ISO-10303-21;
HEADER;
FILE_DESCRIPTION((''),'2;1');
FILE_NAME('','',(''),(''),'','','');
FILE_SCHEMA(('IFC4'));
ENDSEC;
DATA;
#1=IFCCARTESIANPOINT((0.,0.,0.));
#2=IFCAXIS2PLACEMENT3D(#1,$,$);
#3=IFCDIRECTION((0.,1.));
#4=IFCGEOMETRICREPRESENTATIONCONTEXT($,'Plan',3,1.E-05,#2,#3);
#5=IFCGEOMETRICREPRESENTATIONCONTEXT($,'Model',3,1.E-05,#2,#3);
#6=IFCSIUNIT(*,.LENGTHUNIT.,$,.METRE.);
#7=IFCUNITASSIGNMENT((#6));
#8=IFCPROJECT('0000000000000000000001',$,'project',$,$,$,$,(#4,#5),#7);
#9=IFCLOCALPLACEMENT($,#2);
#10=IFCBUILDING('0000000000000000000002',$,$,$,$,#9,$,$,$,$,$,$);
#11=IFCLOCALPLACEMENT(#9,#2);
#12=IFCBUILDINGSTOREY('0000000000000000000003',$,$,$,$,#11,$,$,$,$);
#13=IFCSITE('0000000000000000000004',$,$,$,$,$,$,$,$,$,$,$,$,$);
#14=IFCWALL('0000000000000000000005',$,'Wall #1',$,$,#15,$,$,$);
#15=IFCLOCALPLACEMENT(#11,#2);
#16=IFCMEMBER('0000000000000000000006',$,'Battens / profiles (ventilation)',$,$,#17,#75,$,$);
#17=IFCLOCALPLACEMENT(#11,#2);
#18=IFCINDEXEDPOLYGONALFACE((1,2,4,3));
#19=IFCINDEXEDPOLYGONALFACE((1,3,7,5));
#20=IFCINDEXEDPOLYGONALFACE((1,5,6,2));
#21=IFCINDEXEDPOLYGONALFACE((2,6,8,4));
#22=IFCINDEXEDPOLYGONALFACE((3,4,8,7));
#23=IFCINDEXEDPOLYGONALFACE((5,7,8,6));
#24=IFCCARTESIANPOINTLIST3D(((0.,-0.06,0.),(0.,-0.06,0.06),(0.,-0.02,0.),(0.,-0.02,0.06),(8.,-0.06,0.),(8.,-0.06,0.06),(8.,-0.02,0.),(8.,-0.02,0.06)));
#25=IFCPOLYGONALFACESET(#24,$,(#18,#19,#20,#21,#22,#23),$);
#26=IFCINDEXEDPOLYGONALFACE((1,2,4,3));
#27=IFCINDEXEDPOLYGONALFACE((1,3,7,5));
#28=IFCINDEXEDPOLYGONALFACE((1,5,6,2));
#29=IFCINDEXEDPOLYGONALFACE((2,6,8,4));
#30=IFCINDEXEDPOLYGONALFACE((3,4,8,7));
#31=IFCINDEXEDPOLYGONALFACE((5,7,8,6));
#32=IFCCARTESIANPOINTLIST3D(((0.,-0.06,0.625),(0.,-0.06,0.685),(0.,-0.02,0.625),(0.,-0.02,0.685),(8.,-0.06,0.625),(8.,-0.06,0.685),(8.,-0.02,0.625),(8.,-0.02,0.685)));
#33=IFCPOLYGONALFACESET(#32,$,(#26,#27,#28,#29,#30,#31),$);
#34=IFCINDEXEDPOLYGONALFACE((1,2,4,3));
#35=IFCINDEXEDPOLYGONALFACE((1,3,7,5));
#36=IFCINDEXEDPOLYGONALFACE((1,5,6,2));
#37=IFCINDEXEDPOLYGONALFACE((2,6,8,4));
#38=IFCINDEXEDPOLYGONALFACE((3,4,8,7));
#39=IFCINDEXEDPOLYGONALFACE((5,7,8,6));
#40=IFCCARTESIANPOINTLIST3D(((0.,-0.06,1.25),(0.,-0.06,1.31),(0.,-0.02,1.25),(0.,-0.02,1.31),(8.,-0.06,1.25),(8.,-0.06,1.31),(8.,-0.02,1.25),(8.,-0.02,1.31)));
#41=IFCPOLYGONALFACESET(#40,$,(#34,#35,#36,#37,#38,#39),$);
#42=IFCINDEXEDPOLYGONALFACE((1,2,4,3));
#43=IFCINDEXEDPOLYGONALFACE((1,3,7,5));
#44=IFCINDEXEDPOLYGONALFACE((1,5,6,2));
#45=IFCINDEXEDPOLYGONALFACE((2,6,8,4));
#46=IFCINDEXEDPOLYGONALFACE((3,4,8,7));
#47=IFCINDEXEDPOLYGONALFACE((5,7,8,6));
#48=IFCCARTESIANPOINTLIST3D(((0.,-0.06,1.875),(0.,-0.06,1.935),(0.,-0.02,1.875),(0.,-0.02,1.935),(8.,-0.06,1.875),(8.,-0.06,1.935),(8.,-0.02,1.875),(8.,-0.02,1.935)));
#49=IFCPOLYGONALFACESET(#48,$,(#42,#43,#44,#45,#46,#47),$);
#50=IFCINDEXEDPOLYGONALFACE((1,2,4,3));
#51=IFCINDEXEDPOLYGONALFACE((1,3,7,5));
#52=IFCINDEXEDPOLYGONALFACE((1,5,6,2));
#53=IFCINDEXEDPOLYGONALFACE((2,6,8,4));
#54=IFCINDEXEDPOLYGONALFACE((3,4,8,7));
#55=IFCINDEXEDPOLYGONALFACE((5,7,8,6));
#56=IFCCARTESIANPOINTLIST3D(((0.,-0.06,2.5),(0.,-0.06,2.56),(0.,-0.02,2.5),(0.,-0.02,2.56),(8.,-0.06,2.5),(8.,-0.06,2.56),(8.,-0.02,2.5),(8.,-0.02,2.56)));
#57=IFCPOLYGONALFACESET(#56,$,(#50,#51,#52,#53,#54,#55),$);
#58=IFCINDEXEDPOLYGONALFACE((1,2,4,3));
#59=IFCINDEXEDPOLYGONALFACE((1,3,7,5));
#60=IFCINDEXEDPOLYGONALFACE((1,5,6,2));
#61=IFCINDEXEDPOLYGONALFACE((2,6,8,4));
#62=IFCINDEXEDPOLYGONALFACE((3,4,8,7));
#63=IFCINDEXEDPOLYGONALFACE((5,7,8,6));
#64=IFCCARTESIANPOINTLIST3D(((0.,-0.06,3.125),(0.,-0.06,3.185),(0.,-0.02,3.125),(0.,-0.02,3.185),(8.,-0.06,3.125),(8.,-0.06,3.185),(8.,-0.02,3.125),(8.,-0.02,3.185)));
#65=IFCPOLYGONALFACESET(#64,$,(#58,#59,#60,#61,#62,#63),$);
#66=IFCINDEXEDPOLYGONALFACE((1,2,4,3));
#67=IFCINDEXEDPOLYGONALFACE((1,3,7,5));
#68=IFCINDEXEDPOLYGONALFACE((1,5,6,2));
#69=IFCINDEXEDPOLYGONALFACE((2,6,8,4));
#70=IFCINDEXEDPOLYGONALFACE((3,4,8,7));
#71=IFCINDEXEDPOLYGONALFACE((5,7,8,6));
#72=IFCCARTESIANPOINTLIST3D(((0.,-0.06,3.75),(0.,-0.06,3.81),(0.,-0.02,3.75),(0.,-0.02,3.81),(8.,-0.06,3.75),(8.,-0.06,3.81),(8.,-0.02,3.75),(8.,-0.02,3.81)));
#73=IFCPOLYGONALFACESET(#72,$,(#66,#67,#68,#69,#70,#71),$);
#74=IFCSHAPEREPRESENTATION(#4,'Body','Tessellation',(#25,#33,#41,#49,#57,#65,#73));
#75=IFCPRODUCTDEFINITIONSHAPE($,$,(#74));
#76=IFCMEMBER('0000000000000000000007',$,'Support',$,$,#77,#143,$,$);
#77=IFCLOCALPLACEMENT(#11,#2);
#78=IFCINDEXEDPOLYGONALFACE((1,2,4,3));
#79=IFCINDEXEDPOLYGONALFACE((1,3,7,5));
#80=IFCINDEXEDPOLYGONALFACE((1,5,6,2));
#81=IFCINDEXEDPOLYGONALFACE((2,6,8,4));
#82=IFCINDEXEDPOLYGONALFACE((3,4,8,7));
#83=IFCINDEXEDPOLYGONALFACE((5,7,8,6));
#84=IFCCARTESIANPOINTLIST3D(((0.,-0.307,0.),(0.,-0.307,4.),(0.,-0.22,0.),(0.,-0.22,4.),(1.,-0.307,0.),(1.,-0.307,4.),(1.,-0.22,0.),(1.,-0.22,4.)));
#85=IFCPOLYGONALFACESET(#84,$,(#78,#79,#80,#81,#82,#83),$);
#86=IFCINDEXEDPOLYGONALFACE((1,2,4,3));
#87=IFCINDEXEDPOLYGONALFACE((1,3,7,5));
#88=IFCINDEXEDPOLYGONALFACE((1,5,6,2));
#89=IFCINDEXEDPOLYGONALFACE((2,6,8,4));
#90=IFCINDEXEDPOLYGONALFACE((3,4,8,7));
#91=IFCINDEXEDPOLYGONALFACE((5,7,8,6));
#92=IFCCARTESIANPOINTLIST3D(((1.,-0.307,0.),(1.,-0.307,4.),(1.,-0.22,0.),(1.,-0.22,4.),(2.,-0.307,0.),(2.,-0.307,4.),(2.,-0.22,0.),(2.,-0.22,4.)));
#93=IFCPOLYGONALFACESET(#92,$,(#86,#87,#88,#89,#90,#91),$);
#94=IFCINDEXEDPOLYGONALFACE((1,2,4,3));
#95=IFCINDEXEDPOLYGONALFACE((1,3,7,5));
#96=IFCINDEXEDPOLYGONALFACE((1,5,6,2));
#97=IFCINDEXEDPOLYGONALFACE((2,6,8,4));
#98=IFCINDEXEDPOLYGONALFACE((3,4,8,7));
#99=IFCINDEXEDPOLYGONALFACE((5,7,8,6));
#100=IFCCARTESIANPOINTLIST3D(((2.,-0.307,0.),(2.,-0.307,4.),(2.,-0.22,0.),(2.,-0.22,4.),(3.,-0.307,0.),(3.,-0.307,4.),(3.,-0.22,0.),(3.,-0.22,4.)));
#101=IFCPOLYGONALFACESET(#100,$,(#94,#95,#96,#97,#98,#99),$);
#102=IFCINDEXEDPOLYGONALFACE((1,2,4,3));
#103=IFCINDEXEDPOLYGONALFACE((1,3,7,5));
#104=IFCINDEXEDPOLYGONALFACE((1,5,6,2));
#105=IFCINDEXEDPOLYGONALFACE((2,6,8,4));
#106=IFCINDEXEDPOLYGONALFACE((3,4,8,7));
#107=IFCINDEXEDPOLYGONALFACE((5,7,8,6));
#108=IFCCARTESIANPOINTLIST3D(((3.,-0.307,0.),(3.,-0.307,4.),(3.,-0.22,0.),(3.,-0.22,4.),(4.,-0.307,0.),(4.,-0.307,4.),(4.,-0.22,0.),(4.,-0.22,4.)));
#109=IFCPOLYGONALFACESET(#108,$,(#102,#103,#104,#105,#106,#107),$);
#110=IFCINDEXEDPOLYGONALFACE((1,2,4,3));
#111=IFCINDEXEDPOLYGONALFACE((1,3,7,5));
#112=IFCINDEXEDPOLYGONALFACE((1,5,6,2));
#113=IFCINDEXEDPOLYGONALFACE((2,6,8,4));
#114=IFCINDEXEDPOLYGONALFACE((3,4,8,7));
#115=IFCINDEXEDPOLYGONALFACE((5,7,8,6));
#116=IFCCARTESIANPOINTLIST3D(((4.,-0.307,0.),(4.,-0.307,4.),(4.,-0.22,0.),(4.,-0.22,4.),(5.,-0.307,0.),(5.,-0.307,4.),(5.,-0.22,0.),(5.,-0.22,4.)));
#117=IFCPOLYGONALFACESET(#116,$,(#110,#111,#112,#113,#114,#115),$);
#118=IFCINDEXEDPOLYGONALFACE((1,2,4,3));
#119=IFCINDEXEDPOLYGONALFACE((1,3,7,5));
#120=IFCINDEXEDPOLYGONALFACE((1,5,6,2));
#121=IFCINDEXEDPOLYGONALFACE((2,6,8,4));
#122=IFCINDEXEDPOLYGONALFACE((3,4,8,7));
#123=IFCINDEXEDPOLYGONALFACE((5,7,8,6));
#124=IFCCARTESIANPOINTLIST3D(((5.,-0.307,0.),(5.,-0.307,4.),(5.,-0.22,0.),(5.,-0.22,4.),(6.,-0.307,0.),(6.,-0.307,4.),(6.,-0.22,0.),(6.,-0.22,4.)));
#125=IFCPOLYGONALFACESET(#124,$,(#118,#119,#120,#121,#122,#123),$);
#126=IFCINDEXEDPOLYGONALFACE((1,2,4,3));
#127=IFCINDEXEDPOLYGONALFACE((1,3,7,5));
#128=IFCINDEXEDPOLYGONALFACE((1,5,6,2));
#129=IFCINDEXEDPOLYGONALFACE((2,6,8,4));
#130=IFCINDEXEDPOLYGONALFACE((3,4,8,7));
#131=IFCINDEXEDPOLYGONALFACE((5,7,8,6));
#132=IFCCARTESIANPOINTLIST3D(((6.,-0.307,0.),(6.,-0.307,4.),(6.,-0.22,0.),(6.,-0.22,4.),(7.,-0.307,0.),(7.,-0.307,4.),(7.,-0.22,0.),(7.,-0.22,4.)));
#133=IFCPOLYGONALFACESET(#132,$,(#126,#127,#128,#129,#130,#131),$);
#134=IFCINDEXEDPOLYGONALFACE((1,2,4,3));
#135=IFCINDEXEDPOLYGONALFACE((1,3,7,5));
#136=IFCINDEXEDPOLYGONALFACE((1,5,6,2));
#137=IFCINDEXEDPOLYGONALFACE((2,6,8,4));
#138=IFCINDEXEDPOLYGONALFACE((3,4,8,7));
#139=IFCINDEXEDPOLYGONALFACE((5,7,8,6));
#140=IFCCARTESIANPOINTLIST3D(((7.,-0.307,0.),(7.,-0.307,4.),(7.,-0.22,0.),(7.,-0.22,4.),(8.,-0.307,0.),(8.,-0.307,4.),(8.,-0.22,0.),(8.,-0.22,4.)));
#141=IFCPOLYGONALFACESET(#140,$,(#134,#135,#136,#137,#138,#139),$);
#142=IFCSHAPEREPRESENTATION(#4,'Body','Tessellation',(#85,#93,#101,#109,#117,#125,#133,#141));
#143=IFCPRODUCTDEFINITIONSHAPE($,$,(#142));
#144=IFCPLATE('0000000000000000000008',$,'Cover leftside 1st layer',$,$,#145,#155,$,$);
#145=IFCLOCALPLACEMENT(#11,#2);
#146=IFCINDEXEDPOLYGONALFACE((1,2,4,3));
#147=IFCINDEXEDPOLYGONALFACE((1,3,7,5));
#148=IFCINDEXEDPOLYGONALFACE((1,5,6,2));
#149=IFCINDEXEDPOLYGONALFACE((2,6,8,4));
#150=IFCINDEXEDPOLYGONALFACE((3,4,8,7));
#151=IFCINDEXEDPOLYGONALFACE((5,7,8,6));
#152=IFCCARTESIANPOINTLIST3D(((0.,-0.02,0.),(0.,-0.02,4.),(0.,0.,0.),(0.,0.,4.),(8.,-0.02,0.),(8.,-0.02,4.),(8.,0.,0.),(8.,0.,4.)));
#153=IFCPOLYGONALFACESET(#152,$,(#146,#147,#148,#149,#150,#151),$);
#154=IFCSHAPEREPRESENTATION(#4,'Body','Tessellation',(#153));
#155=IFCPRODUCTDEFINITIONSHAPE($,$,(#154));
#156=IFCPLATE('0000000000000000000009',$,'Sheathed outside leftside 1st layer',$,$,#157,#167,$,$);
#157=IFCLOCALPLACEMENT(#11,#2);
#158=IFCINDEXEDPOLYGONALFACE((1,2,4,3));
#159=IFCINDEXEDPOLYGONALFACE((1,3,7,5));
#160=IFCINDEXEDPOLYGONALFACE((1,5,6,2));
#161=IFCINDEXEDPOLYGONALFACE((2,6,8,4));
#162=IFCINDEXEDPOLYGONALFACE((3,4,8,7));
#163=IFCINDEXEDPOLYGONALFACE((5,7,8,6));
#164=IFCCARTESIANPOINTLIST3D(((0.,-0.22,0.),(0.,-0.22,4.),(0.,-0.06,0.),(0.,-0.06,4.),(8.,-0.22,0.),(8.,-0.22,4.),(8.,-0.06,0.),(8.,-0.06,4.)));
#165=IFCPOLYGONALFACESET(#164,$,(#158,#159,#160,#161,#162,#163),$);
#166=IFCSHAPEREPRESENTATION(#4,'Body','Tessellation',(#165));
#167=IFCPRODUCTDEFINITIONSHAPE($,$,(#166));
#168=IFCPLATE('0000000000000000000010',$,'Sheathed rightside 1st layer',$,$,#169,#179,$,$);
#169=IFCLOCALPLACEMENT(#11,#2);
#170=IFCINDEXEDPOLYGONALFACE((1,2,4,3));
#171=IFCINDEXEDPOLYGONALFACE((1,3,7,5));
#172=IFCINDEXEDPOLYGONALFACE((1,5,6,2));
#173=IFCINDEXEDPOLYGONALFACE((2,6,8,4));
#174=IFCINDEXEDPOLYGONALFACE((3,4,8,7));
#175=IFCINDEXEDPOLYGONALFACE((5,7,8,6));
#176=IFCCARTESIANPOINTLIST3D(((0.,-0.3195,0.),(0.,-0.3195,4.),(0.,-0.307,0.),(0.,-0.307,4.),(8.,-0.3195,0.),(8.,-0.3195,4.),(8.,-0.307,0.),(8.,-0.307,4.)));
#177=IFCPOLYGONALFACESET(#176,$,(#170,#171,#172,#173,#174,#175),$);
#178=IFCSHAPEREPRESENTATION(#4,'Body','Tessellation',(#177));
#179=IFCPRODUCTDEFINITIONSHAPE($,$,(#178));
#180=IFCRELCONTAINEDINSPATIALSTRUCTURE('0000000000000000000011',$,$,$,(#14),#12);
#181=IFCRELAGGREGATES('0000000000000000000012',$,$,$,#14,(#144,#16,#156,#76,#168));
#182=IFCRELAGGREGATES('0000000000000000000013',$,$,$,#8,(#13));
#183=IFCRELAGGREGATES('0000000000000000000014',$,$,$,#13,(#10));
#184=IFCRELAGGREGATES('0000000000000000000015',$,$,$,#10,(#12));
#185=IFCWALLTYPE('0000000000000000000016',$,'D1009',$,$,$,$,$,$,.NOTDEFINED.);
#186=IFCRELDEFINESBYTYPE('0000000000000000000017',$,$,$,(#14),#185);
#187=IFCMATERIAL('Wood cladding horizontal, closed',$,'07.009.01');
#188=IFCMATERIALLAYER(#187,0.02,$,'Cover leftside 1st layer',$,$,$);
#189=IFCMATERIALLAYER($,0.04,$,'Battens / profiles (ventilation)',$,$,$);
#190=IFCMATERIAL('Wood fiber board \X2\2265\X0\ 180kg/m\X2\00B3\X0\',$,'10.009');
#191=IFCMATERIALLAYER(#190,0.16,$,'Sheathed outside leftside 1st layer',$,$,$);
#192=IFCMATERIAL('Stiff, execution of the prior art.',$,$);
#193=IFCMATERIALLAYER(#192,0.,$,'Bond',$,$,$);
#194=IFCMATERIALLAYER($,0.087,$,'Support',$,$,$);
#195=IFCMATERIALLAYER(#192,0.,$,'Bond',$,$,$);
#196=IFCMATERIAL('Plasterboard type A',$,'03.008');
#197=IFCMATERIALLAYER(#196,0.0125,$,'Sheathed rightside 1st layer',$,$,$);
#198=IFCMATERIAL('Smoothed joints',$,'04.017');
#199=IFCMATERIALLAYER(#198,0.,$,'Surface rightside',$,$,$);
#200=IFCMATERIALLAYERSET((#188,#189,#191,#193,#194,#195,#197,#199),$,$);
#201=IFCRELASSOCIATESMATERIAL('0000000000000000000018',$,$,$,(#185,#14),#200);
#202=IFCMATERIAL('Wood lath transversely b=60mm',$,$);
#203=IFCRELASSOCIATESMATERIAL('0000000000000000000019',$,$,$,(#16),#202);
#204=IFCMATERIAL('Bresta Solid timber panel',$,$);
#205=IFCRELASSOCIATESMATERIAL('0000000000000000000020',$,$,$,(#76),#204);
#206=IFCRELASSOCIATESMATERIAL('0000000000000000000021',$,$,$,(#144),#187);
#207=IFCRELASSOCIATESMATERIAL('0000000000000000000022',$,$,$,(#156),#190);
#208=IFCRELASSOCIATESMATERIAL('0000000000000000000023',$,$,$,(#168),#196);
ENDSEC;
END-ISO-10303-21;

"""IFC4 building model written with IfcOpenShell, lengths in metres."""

from ifc_helpers import new_model, si_unit, direction, frame, frame_2d, origin, origin_with_axes, place, context, project, spatial, rectangle, extrude, material, layer, layer_set, type_object, element, aggregate, save


model = new_model("IFC4")

# Units and contexts
plan_context = context("Plan", 3, precision=1e-05, world=origin(), true_north=direction((0.0, 1.0)))
model_context = context("Model", 3, precision=1e-05, world=origin(), true_north=direction((0.0, 1.0)))
ifc_project = project(units=[si_unit("LENGTHUNIT", "METRE")], contexts=[plan_context, model_context])

# Site, building, storey
site = spatial("IfcSite", under=ifc_project)
building_placement = place(None, origin())
building = spatial("IfcBuilding", under=site, at=building_placement)
storey_placement = place(building_placement, origin())
storey = spatial("IfcBuildingStorey", under=building, at=storey_placement)

# Wall, members, plates
ifc_material_1 = material(Name="Wood cladding horizontal, closed", Category="07.009.01")
ifc_layer_1 = layer(ifc_material_1, 0.02, Name="Cover leftside 1st layer")
ifc_layer_2 = layer(None, 0.04, Name="Battens / profiles (ventilation)")
ifc_material_2 = material(Name="Wood fiber board ≥ 180kg/m³", Category="10.009")
ifc_layer_3 = layer(ifc_material_2, 0.16, Name="Sheathed outside leftside 1st layer")
ifc_material_3 = material(Name="Stiff, execution of the prior art.")
ifc_layer_4 = layer(ifc_material_3, 0.0, Name="Bond")
ifc_layer_5 = layer(None, 0.087, Name="Support")
ifc_layer_6 = layer(ifc_material_3, 0.0, Name="Bond")
ifc_material_4 = material(Name="Plasterboard type A", Category="03.008")
ifc_layer_7 = layer(ifc_material_4, 0.0125, Name="Sheathed rightside 1st layer")
ifc_material_5 = material(Name="Smoothed joints", Category="04.017")
ifc_layer_8 = layer(ifc_material_5, 0.0, Name="Surface rightside")
ifc_layer_set = layer_set([ifc_layer_1, ifc_layer_2, ifc_layer_3, ifc_layer_4, ifc_layer_5, ifc_layer_6, ifc_layer_7, ifc_layer_8])
wall_type = type_object("IfcWallType", Name="D1009", PredefinedType="NOTDEFINED", material=ifc_layer_set)
wall_placement = place(None, frame((0.0, 0.0, 0.0), z_axis=(0.0, -1.0, 0.0), x_axis=(1.0, 0.0, 0.0)))
wall = element("IfcWall", 1, at=wall_placement, inside=storey, type_object=wall_type, material=ifc_layer_set, Name="Wall #1")
ifc_material_6 = material(Name="Wood lath transversely b=60mm")
member_1_placement = place(wall_placement, origin())
member_1 = element("IfcMember", 2, at=member_1_placement, material=ifc_material_6, Name="Battens / profiles (ventilation)", context=plan_context, shape_type="SweptSolid", body=[
    extrude(rectangle(XDim=0.06, YDim=0.04, at=frame_2d((0.03, 0.02), x_axis=(1.0, 0.0))), frame((0.0, 0.0, 0.02), z_axis=(1.0, 0.0, 0.0), x_axis=(0.0, 1.0, 0.0)), (0.0, 0.0, 1.0), 8.0),
    extrude(rectangle(XDim=0.06, YDim=0.04, at=frame_2d((0.03, 0.02), x_axis=(1.0, 0.0))), frame((0.0, 0.625, 0.02), z_axis=(1.0, 0.0, 0.0), x_axis=(0.0, 1.0, 0.0)), (0.0, 0.0, 1.0), 8.0),
    extrude(rectangle(XDim=0.06, YDim=0.04, at=frame_2d((0.03, 0.02), x_axis=(1.0, 0.0))), frame((0.0, 1.25, 0.02), z_axis=(1.0, 0.0, 0.0), x_axis=(0.0, 1.0, 0.0)), (0.0, 0.0, 1.0), 8.0),
    extrude(rectangle(XDim=0.06, YDim=0.04, at=frame_2d((0.03, 0.02), x_axis=(1.0, 0.0))), frame((0.0, 1.875, 0.02), z_axis=(1.0, 0.0, 0.0), x_axis=(0.0, 1.0, 0.0)), (0.0, 0.0, 1.0), 8.0),
    extrude(rectangle(XDim=0.06, YDim=0.04, at=frame_2d((0.03, 0.02), x_axis=(1.0, 0.0))), frame((0.0, 2.5, 0.02), z_axis=(1.0, 0.0, 0.0), x_axis=(0.0, 1.0, 0.0)), (0.0, 0.0, 1.0), 8.0),
    extrude(rectangle(XDim=0.06, YDim=0.04, at=frame_2d((0.03, 0.02), x_axis=(1.0, 0.0))), frame((0.0, 3.125, 0.02), z_axis=(1.0, 0.0, 0.0), x_axis=(0.0, 1.0, 0.0)), (0.0, 0.0, 1.0), 8.0),
    extrude(rectangle(XDim=0.06, YDim=0.04, at=frame_2d((0.03, 0.02), x_axis=(1.0, 0.0))), frame((0.0, 3.75, 0.02), z_axis=(1.0, 0.0, 0.0), x_axis=(0.0, 1.0, 0.0)), (0.0, 0.0, 1.0), 8.0),
])
ifc_material_7 = material(Name="Bresta Solid timber panel")
member_2_placement = place(wall_placement, origin())
member_2 = element("IfcMember", 3, at=member_2_placement, material=ifc_material_7, Name="Support", context=plan_context, shape_type="SweptSolid", body=[
    extrude(rectangle(XDim=1.0, YDim=0.087, at=frame_2d((0.5, 0.0435), x_axis=(1.0, 0.0))), frame((0.0, 4.0, 0.22), z_axis=(0.0, -1.0, 0.0), x_axis=(1.0, 0.0, 0.0)), (0.0, 0.0, 1.0), 4.0),
    extrude(rectangle(XDim=1.0, YDim=0.087, at=frame_2d((0.5, 0.0435), x_axis=(1.0, 0.0))), frame((1.0, 4.0, 0.22), z_axis=(0.0, -1.0, 0.0), x_axis=(1.0, 0.0, 0.0)), (0.0, 0.0, 1.0), 4.0),
    extrude(rectangle(XDim=1.0, YDim=0.087, at=frame_2d((0.5, 0.0435), x_axis=(1.0, 0.0))), frame((2.0, 4.0, 0.22), z_axis=(0.0, -1.0, 0.0), x_axis=(1.0, 0.0, 0.0)), (0.0, 0.0, 1.0), 4.0),
    extrude(rectangle(XDim=1.0, YDim=0.087, at=frame_2d((0.5, 0.0435), x_axis=(1.0, 0.0))), frame((3.0, 4.0, 0.22), z_axis=(0.0, -1.0, 0.0), x_axis=(1.0, 0.0, 0.0)), (0.0, 0.0, 1.0), 4.0),
    extrude(rectangle(XDim=1.0, YDim=0.087, at=frame_2d((0.5, 0.0435), x_axis=(1.0, 0.0))), frame((4.0, 4.0, 0.22), z_axis=(0.0, -1.0, 0.0), x_axis=(1.0, 0.0, 0.0)), (0.0, 0.0, 1.0), 4.0),
    extrude(rectangle(XDim=1.0, YDim=0.087, at=frame_2d((0.5, 0.0435), x_axis=(1.0, 0.0))), frame((5.0, 4.0, 0.22), z_axis=(0.0, -1.0, 0.0), x_axis=(1.0, 0.0, 0.0)), (0.0, 0.0, 1.0), 4.0),
    extrude(rectangle(XDim=1.0, YDim=0.087, at=frame_2d((0.5, 0.0435), x_axis=(1.0, 0.0))), frame((6.0, 4.0, 0.22), z_axis=(0.0, -1.0, 0.0), x_axis=(1.0, 0.0, 0.0)), (0.0, 0.0, 1.0), 4.0),
    extrude(rectangle(XDim=1.0, YDim=0.087, at=frame_2d((0.5, 0.0435), x_axis=(1.0, 0.0))), frame((7.0, 4.0, 0.22), z_axis=(0.0, -1.0, 0.0), x_axis=(1.0, 0.0, 0.0)), (0.0, 0.0, 1.0), 4.0),
])
plate_1_placement = place(wall_placement, origin())
plate_1 = element("IfcPlate", 4, at=plate_1_placement, material=ifc_material_1, Name="Cover leftside 1st layer", context=plan_context, shape_type="SweptSolid", body=[
    extrude(rectangle(XDim=8.0, YDim=4.0, at=frame_2d((4.0, 2.0), x_axis=(1.0, 0.0))), origin_with_axes(), (0.0, 0.0, 1.0), 0.02),
])
plate_2_placement = place(wall_placement, origin())
plate_2 = element("IfcPlate", 5, at=plate_2_placement, material=ifc_material_2, Name="Sheathed outside leftside 1st layer", context=plan_context, shape_type="SweptSolid", body=[
    extrude(rectangle(XDim=8.0, YDim=4.0, at=frame_2d((4.0, 2.0), x_axis=(1.0, 0.0))), frame((0.0, 0.0, 0.06), z_axis=(0.0, 0.0, 1.0), x_axis=(1.0, 0.0, 0.0)), (0.0, 0.0, 1.0), 0.16),
])
plate_3_placement = place(wall_placement, origin())
plate_3 = element("IfcPlate", 6, at=plate_3_placement, material=ifc_material_4, Name="Sheathed rightside 1st layer", context=plan_context, shape_type="SweptSolid", body=[
    extrude(rectangle(XDim=8.0, YDim=4.0, at=frame_2d((4.0, 2.0), x_axis=(1.0, 0.0))), frame((0.0, 0.0, 0.307), z_axis=(0.0, 0.0, 1.0), x_axis=(1.0, 0.0, 0.0)), (0.0, 0.0, 1.0), 0.0125),
])
aggregate(wall, [plate_1, member_1, plate_2, member_2, plate_3])

save(model, "model.ifc")
